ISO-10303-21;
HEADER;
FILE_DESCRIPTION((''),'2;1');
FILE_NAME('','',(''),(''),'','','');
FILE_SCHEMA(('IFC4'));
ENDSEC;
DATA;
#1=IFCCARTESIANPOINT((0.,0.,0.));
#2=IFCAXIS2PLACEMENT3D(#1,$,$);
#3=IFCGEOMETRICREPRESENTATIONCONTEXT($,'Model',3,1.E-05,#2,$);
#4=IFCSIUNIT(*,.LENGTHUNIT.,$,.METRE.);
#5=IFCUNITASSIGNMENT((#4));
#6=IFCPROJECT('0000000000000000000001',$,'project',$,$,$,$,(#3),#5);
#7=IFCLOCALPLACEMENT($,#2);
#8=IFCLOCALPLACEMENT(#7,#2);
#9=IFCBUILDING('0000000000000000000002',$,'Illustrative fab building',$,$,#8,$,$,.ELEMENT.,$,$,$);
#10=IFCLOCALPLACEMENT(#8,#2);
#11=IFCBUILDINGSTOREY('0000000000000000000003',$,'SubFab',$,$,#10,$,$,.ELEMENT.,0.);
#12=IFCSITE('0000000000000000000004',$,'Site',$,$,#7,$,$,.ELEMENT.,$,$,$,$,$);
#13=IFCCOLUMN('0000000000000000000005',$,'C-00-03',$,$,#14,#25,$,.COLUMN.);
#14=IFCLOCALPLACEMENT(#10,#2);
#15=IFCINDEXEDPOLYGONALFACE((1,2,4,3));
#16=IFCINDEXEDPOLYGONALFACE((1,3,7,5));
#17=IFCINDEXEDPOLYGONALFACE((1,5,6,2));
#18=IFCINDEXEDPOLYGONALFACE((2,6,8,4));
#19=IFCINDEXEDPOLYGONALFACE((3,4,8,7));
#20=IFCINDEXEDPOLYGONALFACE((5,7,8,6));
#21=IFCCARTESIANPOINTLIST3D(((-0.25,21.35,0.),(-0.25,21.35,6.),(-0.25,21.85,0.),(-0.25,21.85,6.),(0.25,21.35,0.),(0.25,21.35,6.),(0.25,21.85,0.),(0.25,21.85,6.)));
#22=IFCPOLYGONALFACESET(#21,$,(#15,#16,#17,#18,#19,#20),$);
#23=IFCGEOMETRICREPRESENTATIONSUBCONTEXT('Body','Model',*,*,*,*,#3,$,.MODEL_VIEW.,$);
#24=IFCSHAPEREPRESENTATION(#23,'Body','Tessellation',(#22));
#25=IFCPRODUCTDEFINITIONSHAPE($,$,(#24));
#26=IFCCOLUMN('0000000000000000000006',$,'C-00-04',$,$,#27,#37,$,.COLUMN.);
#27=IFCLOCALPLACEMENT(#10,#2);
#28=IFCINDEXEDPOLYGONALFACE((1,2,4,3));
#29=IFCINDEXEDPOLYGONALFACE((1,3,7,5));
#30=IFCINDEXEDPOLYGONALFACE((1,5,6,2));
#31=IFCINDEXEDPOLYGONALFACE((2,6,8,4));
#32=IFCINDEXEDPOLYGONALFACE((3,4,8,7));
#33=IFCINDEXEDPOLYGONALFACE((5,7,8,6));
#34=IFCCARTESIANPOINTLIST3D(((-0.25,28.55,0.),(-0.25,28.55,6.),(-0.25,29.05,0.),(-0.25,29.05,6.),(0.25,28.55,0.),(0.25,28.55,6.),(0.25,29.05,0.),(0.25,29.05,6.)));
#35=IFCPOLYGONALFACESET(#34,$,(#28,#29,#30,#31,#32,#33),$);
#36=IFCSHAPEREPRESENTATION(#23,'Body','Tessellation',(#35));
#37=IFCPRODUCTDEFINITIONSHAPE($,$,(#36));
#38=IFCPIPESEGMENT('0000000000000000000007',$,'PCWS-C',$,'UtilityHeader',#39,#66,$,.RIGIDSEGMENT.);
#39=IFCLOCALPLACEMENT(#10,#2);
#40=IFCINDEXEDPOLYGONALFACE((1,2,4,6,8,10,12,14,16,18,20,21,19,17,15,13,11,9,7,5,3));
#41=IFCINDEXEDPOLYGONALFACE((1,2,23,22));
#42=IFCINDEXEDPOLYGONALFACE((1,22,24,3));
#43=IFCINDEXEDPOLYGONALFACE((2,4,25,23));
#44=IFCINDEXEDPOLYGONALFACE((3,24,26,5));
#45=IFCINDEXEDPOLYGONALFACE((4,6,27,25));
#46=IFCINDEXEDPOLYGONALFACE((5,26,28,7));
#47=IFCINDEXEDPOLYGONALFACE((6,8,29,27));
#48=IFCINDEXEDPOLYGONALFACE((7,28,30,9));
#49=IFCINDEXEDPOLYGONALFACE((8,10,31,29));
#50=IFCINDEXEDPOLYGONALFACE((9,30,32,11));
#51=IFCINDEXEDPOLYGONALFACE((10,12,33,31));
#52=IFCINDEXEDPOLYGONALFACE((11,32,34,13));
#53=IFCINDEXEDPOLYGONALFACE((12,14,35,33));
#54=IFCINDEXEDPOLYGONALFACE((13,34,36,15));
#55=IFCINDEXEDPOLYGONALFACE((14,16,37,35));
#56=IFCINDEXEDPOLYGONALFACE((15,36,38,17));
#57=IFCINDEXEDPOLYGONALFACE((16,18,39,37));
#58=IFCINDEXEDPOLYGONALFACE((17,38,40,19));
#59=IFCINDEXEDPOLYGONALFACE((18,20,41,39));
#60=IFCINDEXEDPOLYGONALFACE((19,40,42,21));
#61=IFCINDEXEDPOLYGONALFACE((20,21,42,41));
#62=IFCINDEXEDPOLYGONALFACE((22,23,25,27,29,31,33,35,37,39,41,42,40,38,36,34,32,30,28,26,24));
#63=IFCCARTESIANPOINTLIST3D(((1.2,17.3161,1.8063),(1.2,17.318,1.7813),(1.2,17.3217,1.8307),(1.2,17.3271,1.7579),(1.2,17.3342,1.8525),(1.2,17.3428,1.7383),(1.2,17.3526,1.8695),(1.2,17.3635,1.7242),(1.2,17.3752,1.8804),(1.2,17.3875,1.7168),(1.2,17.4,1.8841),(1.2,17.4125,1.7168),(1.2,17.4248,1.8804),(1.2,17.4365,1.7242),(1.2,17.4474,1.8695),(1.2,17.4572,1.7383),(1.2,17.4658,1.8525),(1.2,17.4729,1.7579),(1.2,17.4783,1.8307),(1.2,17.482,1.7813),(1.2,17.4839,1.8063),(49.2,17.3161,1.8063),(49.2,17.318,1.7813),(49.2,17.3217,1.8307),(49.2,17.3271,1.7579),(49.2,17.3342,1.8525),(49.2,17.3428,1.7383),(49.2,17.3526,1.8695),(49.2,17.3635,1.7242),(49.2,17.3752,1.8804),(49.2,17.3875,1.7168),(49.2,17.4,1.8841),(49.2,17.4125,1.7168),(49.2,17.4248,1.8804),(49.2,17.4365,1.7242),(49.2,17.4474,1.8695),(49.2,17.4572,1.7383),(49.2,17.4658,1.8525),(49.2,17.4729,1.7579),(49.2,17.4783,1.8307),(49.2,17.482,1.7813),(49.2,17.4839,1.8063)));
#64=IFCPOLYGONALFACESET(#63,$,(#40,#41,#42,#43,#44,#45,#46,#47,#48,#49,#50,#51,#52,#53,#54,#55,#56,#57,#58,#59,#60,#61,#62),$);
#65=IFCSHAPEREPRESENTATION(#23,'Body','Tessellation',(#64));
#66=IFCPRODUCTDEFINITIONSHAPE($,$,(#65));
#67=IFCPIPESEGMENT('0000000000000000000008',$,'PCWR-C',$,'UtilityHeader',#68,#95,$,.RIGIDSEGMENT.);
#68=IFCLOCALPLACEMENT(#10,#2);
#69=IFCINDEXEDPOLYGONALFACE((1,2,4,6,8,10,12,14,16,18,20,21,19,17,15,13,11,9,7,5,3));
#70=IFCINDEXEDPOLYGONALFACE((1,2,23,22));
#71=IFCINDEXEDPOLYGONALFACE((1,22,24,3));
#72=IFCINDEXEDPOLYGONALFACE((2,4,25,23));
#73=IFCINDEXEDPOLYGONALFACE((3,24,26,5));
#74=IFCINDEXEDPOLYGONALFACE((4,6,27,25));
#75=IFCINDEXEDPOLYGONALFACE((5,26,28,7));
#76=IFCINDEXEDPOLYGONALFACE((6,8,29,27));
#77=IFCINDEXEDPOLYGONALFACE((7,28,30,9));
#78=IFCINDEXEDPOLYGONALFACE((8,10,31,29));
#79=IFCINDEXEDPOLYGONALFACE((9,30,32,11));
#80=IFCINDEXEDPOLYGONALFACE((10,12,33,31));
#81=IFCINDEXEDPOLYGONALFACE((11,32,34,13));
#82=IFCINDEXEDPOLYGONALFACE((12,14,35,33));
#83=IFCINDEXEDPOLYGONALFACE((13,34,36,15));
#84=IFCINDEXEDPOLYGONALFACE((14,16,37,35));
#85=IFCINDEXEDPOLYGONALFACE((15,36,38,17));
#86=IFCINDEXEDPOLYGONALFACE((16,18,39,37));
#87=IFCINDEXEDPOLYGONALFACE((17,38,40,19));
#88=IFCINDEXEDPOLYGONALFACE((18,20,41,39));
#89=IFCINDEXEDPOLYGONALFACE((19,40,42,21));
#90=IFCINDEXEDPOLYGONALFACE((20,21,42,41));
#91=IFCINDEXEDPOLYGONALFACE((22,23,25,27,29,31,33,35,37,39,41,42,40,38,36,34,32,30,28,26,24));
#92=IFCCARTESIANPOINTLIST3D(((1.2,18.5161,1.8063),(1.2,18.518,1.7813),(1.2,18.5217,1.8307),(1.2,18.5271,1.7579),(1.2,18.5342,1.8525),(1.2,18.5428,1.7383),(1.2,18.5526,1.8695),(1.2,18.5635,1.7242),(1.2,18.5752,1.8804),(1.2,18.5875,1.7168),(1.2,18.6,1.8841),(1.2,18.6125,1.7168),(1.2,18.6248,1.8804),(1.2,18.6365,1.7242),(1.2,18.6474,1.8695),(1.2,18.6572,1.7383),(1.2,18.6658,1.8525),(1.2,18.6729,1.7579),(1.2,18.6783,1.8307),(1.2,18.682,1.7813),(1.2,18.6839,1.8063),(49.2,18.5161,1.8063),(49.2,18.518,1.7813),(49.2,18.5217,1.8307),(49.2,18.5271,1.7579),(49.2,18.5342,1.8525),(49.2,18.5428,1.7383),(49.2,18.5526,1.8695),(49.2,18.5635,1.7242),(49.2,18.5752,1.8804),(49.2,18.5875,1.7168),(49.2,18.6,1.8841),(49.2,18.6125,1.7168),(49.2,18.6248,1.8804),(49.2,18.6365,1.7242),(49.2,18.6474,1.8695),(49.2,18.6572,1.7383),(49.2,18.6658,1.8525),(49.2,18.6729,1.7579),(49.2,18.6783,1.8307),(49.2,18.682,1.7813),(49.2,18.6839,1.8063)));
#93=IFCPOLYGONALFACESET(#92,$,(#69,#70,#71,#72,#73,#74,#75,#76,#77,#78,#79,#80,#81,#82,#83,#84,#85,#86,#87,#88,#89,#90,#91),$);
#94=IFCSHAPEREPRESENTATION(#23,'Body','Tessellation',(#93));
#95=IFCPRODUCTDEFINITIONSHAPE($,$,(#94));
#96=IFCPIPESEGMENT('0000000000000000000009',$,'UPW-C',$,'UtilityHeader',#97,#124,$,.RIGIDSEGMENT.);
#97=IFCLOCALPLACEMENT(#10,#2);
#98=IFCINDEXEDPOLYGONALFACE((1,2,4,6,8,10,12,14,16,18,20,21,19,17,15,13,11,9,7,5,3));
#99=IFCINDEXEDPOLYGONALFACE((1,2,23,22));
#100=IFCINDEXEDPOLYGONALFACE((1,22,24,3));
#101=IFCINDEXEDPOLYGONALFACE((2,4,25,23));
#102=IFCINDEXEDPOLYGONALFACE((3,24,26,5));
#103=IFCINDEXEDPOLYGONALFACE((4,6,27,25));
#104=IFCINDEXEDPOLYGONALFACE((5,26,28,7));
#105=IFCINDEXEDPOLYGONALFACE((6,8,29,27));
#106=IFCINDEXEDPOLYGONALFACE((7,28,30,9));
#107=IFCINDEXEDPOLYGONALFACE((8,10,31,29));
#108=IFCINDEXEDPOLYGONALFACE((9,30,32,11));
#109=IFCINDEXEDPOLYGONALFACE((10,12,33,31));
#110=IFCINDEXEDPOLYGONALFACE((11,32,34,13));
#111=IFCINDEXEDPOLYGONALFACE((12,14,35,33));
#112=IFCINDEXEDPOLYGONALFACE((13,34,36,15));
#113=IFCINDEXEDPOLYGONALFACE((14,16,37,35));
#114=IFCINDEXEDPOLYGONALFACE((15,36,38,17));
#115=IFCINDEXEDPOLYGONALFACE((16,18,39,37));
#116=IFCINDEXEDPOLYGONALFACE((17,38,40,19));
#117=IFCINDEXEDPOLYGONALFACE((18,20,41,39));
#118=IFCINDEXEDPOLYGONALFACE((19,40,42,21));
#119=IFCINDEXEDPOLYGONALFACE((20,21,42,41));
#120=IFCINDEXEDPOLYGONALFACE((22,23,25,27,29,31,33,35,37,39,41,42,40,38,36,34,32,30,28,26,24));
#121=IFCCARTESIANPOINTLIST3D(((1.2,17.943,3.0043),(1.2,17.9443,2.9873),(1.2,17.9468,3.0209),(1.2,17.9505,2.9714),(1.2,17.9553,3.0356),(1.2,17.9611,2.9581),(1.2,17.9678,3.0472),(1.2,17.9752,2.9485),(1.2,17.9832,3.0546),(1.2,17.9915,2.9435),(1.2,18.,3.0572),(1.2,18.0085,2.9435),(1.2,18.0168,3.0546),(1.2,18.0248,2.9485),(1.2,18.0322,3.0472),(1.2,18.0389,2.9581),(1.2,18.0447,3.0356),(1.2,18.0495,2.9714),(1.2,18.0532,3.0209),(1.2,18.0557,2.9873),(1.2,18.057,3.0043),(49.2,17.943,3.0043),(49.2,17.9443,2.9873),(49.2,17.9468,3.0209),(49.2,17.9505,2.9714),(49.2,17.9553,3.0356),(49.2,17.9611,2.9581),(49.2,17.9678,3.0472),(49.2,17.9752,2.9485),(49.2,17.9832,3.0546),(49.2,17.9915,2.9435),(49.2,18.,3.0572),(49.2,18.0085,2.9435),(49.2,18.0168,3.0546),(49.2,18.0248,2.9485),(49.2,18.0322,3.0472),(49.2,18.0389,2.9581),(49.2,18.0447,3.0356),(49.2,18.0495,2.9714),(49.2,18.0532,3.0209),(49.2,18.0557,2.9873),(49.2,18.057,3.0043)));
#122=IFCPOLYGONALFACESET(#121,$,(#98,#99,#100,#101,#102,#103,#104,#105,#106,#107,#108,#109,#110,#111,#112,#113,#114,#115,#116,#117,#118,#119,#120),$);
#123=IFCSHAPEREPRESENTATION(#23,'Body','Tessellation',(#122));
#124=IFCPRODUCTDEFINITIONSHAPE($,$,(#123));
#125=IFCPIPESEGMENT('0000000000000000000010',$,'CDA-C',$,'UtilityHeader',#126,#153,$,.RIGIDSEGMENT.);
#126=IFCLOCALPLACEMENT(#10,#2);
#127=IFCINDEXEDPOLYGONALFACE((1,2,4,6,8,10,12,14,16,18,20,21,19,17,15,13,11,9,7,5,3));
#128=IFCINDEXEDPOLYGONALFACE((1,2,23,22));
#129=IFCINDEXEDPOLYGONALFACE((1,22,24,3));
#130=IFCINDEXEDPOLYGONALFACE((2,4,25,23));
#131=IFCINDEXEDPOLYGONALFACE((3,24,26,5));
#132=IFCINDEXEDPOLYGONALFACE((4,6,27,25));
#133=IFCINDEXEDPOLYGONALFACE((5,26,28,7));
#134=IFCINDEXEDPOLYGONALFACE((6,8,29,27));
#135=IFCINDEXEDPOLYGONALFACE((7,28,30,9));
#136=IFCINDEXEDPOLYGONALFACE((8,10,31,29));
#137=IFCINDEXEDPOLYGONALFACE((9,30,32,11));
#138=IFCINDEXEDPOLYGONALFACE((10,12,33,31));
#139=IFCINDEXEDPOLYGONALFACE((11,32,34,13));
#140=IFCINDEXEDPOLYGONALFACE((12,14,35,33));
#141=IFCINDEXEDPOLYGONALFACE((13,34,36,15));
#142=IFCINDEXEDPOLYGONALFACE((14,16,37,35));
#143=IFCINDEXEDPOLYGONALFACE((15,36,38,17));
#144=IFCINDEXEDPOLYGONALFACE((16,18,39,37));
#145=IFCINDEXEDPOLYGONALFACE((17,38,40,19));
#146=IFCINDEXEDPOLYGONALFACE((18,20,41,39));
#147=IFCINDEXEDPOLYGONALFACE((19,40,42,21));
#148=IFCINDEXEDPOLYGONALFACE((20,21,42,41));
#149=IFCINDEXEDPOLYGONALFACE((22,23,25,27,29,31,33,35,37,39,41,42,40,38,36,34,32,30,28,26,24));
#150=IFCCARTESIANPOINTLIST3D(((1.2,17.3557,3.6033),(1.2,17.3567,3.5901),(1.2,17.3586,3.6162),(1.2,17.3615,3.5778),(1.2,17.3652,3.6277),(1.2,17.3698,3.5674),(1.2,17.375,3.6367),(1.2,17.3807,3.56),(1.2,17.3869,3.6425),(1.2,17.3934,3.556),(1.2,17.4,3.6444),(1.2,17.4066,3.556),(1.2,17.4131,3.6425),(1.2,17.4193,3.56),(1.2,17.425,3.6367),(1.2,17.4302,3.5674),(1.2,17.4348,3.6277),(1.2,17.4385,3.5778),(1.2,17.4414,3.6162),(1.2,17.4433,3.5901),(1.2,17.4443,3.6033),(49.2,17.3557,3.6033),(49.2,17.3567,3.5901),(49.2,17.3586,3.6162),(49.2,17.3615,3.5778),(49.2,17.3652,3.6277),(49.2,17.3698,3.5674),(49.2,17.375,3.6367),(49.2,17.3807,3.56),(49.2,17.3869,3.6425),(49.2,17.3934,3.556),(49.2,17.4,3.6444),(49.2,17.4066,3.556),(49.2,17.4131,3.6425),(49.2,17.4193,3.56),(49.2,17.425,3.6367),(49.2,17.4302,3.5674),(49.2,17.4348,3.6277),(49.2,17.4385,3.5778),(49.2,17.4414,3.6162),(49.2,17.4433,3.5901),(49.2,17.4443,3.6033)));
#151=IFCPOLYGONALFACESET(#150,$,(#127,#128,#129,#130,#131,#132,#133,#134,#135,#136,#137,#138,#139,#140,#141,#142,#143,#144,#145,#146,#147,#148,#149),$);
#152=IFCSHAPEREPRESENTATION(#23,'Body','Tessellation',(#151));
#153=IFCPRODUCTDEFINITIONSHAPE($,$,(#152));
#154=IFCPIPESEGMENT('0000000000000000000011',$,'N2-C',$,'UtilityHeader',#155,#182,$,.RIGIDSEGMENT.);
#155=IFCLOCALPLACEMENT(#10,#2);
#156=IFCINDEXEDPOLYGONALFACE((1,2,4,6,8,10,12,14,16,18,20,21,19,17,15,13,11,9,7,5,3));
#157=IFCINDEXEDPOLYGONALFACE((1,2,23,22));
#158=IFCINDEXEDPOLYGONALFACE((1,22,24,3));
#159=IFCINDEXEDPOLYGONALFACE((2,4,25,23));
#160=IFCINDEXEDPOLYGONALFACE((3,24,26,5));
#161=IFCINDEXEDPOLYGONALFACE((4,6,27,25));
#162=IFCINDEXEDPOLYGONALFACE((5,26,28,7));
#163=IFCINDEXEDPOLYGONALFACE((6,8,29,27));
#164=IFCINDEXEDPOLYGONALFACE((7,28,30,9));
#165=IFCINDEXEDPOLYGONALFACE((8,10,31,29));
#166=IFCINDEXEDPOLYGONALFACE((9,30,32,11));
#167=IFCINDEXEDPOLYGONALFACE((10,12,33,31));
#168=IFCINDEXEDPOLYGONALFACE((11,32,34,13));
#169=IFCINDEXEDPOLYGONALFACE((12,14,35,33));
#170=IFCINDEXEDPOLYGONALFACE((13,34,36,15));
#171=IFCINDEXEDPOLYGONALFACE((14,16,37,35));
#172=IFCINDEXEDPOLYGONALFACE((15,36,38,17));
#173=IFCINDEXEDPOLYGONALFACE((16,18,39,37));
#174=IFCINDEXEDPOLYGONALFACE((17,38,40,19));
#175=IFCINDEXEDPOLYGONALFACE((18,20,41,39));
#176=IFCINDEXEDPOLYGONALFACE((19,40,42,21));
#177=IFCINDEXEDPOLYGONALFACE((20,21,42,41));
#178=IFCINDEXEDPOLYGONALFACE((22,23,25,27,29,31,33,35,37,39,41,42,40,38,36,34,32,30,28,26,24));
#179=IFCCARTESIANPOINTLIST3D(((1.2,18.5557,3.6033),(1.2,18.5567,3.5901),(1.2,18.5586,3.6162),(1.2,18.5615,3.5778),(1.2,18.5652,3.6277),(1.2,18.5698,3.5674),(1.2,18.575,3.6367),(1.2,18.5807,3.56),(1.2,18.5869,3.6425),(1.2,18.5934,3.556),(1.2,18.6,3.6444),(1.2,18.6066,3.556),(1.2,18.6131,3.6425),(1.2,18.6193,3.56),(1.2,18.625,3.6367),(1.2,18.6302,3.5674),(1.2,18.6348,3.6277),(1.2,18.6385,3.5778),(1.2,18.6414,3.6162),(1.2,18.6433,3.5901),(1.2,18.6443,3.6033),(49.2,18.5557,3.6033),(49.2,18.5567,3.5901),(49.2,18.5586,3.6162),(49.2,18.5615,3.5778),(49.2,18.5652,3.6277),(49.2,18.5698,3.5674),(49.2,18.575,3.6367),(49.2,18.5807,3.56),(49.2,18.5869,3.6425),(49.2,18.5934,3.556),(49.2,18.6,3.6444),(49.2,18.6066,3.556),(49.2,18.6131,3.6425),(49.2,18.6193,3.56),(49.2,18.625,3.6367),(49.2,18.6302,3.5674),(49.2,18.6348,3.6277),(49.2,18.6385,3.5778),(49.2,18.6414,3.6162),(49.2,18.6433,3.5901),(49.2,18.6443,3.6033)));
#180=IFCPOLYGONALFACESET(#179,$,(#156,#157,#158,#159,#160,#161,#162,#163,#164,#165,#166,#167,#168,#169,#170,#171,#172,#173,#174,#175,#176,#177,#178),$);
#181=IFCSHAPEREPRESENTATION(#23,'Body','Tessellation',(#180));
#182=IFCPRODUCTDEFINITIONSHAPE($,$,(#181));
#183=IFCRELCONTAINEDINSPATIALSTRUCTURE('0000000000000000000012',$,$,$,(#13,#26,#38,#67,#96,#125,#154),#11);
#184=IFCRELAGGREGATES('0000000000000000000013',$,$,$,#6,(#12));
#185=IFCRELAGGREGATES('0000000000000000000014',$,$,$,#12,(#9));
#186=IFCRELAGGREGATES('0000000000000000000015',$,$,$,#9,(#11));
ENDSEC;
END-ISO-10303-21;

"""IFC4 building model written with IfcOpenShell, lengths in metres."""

from ifc_helpers import new_model, entity, si_unit, frame, origin, origin_2d, place, context, subcontext, project, spatial, rectangle, extrude, element, save


model = new_model("IFC4")

# Units and contexts
model_context = context("Model", 3, precision=1e-05, world=origin())
body_context = subcontext(model_context, "Body", "Model", "MODEL_VIEW")
ifc_project = project(units=[si_unit("LENGTHUNIT", "METRE")], contexts=[model_context])

# Site, building, storey
site_placement = place(None, origin())
site = spatial("IfcSite", under=ifc_project, at=site_placement, Name="Site", CompositionType="ELEMENT")
building_placement = place(site_placement, origin())
building = spatial("IfcBuilding", under=site, at=building_placement, Name="Illustrative fab building", CompositionType="ELEMENT")
storey_placement = place(building_placement, origin())
storey = spatial("IfcBuildingStorey", under=building, at=storey_placement, Name="SubFab", CompositionType="ELEMENT", Elevation=0.0)

# Columns
for number, where, name in (
    (1, (0.0, 21.6, 0.0), "C-00-03"),
    (2, (0.0, 28.8, 0.0), "C-00-04"),
):
    element("IfcColumn", number, at=place(storey_placement, frame(where)), inside=storey, Name=name, PredefinedType="COLUMN", context=body_context, shape_type="SweptSolid", body=[
        extrude(rectangle(XDim=0.5, YDim=0.5, at=origin_2d()), origin(), (0.0, 0.0, 1.0), 6.0),
    ])

# Pipe segments
for number, where, name in (
    (3, (1.2, 17.4, 1.8), "PCWS-C"),
    (4, (1.2, 18.6, 1.8), "PCWR-C"),
):
    element("IfcPipeSegment", number, at=place(storey_placement, frame(where)), inside=storey, Name=name, ObjectType="UtilityHeader", PredefinedType="RIGIDSEGMENT", context=body_context, shape_type="AdvancedSweptSolid", body=[
        entity("IfcSweptDiskSolid", entity("IfcPolyline", [entity("IfcCartesianPoint", [0.0, 0.0, 0.0]), entity("IfcCartesianPoint", [48.0, 0.0, 0.0])]), 0.0841),
    ])
pipe_segment_placement = place(storey_placement, frame((1.2, 18.0, 3.0)))
element("IfcPipeSegment", 5, at=pipe_segment_placement, inside=storey, Name="UPW-C", ObjectType="UtilityHeader", PredefinedType="RIGIDSEGMENT", context=body_context, shape_type="AdvancedSweptSolid", body=[
    entity("IfcSweptDiskSolid", entity("IfcPolyline", [entity("IfcCartesianPoint", [0.0, 0.0, 0.0]), entity("IfcCartesianPoint", [48.0, 0.0, 0.0])]), 0.0571),
])
for number, where, name in (
    (6, (1.2, 17.4, 3.6), "CDA-C"),
    (7, (1.2, 18.6, 3.6), "N2-C"),
):
    element("IfcPipeSegment", number, at=place(storey_placement, frame(where)), inside=storey, Name=name, ObjectType="UtilityHeader", PredefinedType="RIGIDSEGMENT", context=body_context, shape_type="AdvancedSweptSolid", body=[
        entity("IfcSweptDiskSolid", entity("IfcPolyline", [entity("IfcCartesianPoint", [0.0, 0.0, 0.0]), entity("IfcCartesianPoint", [48.0, 0.0, 0.0])]), 0.0445),
    ])

save(model, "model.ifc")
